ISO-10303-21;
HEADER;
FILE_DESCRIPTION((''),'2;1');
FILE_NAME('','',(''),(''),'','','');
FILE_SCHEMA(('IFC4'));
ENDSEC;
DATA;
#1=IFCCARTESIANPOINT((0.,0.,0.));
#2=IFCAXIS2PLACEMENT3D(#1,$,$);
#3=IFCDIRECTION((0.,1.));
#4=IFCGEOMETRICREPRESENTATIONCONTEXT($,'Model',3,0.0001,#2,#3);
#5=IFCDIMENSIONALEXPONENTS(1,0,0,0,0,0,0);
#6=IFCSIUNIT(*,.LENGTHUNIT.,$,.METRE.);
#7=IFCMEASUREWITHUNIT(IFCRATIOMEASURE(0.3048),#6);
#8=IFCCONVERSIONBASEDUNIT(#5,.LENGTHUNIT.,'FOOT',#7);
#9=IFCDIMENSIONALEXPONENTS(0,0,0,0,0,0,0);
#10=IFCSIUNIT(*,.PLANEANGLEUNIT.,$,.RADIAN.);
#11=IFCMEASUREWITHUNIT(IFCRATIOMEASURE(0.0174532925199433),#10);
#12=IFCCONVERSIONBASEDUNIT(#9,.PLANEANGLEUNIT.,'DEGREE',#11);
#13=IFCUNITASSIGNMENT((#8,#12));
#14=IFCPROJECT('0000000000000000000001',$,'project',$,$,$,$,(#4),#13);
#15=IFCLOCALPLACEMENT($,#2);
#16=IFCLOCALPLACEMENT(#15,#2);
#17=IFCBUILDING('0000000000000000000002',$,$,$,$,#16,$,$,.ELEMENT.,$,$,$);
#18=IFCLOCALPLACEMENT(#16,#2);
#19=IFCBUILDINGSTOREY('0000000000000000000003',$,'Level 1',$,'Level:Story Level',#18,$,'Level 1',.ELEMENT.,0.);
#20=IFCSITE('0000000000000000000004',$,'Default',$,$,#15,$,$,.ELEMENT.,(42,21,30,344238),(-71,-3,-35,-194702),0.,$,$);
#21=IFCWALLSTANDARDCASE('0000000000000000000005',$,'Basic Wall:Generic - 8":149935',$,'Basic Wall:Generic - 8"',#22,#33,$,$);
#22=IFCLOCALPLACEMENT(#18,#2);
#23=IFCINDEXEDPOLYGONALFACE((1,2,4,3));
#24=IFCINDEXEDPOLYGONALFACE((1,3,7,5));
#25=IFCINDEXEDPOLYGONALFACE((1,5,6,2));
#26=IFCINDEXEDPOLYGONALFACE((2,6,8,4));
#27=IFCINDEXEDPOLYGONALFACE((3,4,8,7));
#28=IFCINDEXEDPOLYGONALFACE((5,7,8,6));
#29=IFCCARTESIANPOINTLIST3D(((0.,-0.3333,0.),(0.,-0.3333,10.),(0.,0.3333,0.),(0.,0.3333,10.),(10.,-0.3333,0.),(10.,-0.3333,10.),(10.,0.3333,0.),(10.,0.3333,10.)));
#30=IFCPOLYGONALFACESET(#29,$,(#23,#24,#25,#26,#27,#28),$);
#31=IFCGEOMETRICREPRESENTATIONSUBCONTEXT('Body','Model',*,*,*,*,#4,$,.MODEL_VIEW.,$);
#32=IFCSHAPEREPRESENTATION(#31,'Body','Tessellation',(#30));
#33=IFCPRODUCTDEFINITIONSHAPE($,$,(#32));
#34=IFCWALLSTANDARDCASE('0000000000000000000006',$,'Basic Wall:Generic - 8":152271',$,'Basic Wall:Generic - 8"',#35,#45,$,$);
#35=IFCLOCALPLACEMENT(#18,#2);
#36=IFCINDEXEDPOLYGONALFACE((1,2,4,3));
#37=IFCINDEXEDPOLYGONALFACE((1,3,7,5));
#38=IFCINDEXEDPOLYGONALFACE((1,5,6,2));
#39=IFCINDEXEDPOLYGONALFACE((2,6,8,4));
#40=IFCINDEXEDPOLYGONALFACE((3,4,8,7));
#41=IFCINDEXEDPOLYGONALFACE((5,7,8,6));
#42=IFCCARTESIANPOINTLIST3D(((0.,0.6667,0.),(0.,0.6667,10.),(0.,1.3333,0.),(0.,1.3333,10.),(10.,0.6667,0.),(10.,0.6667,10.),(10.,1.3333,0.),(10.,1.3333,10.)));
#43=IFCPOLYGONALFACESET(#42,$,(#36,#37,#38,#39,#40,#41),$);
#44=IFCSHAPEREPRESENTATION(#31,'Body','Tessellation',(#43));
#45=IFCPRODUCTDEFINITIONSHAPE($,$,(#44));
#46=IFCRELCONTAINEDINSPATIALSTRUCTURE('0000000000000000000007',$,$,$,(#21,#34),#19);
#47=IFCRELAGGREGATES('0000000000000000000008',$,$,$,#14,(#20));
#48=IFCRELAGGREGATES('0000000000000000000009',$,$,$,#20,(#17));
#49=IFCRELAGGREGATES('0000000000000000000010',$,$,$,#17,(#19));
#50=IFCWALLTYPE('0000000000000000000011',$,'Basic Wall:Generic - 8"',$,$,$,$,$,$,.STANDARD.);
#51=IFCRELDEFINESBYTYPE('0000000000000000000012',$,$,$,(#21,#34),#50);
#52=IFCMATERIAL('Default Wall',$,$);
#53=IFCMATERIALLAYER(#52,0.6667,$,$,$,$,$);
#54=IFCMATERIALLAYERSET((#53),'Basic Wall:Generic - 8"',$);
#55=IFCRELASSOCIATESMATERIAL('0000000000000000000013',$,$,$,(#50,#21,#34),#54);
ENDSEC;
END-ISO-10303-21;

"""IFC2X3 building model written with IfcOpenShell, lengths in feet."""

from ifc_helpers import new_model, entity, si_unit, converted_unit, direction, frame, frame_2d, origin, place, context, subcontext, project, spatial, rectangle, extrude, material, layer, layer_set, layer_usage, type_object, element, save


model = new_model("IFC2X3")

# Units and contexts
model_context = context("Model", 3, precision=0.0001, world=origin(), true_north=direction((0.0, 1.0)))
body_context = subcontext(model_context, "Body", "Model", "MODEL_VIEW")
ifc_project = project(units=[converted_unit("LENGTHUNIT", "FOOT", entity("IfcRatioMeasure", 0.3048), si_unit("LENGTHUNIT", "METRE"), dimensions=[1, 0, 0, 0, 0, 0, 0]), converted_unit("PLANEANGLEUNIT", "DEGREE", entity("IfcRatioMeasure", 0.0174532925199433), si_unit("PLANEANGLEUNIT", "RADIAN"), dimensions=[0, 0, 0, 0, 0, 0, 0])], contexts=[model_context])

# Site, building, storey
site_placement = place(None, origin())
site = spatial("IfcSite", under=ifc_project, at=site_placement, Name="Default", CompositionType="ELEMENT", RefLatitude=(42, 21, 30, 344238), RefLongitude=(-71, -3, -35, -194702), RefElevation=0.0)
building_placement = place(site_placement, origin())
building = spatial("IfcBuilding", under=site, at=building_placement, CompositionType="ELEMENT")
storey_placement = place(building_placement, origin())
storey = spatial("IfcBuildingStorey", under=building, at=storey_placement, Name="Level 1", ObjectType="Level:Story Level", LongName="Level 1", CompositionType="ELEMENT", Elevation=0.0)

# Walls
ifc_material = material(Name="Default Wall")
ifc_layer = layer(ifc_material, 0.6667)
ifc_layer_set = layer_set([ifc_layer], Name="Basic Wall:Generic - 8\"")
ifc_layer_usage_1 = layer_usage(ifc_layer_set, "AXIS2", "NEGATIVE", 0.3333)
wall_type = type_object("IfcWallType", Name="Basic Wall:Generic - 8\"", PredefinedType="STANDARD", material=ifc_layer_set)
wall_1_placement = place(storey_placement, origin())
element("IfcWallStandardCase", 1, at=wall_1_placement, inside=storey, type_object=wall_type, material=ifc_layer_usage_1, Name="Basic Wall:Generic - 8\":149935", ObjectType="Basic Wall:Generic - 8\"", context=body_context, shape_type="SweptSolid", body=[
    extrude(rectangle(XDim=10.0, YDim=0.6667, at=frame_2d((5.0, 0.0), x_axis=(-1.0, 0.0))), origin(), (0.0, 0.0, 1.0), 10.0),
])
ifc_layer_usage_2 = layer_usage(ifc_layer_set, "AXIS2", "NEGATIVE", 0.3333)
wall_2_placement = place(storey_placement, frame((0.0, 1.0, 0.0)))
element("IfcWallStandardCase", 2, at=wall_2_placement, inside=storey, type_object=wall_type, material=ifc_layer_usage_2, Name="Basic Wall:Generic - 8\":152271", ObjectType="Basic Wall:Generic - 8\"", context=body_context, shape_type="SweptSolid", body=[
    extrude(rectangle(XDim=10.0, YDim=0.6667, at=frame_2d((5.0, 0.0), x_axis=(-1.0, 0.0))), origin(), (0.0, 0.0, 1.0), 10.0),
])

save(model, "model.ifc")
